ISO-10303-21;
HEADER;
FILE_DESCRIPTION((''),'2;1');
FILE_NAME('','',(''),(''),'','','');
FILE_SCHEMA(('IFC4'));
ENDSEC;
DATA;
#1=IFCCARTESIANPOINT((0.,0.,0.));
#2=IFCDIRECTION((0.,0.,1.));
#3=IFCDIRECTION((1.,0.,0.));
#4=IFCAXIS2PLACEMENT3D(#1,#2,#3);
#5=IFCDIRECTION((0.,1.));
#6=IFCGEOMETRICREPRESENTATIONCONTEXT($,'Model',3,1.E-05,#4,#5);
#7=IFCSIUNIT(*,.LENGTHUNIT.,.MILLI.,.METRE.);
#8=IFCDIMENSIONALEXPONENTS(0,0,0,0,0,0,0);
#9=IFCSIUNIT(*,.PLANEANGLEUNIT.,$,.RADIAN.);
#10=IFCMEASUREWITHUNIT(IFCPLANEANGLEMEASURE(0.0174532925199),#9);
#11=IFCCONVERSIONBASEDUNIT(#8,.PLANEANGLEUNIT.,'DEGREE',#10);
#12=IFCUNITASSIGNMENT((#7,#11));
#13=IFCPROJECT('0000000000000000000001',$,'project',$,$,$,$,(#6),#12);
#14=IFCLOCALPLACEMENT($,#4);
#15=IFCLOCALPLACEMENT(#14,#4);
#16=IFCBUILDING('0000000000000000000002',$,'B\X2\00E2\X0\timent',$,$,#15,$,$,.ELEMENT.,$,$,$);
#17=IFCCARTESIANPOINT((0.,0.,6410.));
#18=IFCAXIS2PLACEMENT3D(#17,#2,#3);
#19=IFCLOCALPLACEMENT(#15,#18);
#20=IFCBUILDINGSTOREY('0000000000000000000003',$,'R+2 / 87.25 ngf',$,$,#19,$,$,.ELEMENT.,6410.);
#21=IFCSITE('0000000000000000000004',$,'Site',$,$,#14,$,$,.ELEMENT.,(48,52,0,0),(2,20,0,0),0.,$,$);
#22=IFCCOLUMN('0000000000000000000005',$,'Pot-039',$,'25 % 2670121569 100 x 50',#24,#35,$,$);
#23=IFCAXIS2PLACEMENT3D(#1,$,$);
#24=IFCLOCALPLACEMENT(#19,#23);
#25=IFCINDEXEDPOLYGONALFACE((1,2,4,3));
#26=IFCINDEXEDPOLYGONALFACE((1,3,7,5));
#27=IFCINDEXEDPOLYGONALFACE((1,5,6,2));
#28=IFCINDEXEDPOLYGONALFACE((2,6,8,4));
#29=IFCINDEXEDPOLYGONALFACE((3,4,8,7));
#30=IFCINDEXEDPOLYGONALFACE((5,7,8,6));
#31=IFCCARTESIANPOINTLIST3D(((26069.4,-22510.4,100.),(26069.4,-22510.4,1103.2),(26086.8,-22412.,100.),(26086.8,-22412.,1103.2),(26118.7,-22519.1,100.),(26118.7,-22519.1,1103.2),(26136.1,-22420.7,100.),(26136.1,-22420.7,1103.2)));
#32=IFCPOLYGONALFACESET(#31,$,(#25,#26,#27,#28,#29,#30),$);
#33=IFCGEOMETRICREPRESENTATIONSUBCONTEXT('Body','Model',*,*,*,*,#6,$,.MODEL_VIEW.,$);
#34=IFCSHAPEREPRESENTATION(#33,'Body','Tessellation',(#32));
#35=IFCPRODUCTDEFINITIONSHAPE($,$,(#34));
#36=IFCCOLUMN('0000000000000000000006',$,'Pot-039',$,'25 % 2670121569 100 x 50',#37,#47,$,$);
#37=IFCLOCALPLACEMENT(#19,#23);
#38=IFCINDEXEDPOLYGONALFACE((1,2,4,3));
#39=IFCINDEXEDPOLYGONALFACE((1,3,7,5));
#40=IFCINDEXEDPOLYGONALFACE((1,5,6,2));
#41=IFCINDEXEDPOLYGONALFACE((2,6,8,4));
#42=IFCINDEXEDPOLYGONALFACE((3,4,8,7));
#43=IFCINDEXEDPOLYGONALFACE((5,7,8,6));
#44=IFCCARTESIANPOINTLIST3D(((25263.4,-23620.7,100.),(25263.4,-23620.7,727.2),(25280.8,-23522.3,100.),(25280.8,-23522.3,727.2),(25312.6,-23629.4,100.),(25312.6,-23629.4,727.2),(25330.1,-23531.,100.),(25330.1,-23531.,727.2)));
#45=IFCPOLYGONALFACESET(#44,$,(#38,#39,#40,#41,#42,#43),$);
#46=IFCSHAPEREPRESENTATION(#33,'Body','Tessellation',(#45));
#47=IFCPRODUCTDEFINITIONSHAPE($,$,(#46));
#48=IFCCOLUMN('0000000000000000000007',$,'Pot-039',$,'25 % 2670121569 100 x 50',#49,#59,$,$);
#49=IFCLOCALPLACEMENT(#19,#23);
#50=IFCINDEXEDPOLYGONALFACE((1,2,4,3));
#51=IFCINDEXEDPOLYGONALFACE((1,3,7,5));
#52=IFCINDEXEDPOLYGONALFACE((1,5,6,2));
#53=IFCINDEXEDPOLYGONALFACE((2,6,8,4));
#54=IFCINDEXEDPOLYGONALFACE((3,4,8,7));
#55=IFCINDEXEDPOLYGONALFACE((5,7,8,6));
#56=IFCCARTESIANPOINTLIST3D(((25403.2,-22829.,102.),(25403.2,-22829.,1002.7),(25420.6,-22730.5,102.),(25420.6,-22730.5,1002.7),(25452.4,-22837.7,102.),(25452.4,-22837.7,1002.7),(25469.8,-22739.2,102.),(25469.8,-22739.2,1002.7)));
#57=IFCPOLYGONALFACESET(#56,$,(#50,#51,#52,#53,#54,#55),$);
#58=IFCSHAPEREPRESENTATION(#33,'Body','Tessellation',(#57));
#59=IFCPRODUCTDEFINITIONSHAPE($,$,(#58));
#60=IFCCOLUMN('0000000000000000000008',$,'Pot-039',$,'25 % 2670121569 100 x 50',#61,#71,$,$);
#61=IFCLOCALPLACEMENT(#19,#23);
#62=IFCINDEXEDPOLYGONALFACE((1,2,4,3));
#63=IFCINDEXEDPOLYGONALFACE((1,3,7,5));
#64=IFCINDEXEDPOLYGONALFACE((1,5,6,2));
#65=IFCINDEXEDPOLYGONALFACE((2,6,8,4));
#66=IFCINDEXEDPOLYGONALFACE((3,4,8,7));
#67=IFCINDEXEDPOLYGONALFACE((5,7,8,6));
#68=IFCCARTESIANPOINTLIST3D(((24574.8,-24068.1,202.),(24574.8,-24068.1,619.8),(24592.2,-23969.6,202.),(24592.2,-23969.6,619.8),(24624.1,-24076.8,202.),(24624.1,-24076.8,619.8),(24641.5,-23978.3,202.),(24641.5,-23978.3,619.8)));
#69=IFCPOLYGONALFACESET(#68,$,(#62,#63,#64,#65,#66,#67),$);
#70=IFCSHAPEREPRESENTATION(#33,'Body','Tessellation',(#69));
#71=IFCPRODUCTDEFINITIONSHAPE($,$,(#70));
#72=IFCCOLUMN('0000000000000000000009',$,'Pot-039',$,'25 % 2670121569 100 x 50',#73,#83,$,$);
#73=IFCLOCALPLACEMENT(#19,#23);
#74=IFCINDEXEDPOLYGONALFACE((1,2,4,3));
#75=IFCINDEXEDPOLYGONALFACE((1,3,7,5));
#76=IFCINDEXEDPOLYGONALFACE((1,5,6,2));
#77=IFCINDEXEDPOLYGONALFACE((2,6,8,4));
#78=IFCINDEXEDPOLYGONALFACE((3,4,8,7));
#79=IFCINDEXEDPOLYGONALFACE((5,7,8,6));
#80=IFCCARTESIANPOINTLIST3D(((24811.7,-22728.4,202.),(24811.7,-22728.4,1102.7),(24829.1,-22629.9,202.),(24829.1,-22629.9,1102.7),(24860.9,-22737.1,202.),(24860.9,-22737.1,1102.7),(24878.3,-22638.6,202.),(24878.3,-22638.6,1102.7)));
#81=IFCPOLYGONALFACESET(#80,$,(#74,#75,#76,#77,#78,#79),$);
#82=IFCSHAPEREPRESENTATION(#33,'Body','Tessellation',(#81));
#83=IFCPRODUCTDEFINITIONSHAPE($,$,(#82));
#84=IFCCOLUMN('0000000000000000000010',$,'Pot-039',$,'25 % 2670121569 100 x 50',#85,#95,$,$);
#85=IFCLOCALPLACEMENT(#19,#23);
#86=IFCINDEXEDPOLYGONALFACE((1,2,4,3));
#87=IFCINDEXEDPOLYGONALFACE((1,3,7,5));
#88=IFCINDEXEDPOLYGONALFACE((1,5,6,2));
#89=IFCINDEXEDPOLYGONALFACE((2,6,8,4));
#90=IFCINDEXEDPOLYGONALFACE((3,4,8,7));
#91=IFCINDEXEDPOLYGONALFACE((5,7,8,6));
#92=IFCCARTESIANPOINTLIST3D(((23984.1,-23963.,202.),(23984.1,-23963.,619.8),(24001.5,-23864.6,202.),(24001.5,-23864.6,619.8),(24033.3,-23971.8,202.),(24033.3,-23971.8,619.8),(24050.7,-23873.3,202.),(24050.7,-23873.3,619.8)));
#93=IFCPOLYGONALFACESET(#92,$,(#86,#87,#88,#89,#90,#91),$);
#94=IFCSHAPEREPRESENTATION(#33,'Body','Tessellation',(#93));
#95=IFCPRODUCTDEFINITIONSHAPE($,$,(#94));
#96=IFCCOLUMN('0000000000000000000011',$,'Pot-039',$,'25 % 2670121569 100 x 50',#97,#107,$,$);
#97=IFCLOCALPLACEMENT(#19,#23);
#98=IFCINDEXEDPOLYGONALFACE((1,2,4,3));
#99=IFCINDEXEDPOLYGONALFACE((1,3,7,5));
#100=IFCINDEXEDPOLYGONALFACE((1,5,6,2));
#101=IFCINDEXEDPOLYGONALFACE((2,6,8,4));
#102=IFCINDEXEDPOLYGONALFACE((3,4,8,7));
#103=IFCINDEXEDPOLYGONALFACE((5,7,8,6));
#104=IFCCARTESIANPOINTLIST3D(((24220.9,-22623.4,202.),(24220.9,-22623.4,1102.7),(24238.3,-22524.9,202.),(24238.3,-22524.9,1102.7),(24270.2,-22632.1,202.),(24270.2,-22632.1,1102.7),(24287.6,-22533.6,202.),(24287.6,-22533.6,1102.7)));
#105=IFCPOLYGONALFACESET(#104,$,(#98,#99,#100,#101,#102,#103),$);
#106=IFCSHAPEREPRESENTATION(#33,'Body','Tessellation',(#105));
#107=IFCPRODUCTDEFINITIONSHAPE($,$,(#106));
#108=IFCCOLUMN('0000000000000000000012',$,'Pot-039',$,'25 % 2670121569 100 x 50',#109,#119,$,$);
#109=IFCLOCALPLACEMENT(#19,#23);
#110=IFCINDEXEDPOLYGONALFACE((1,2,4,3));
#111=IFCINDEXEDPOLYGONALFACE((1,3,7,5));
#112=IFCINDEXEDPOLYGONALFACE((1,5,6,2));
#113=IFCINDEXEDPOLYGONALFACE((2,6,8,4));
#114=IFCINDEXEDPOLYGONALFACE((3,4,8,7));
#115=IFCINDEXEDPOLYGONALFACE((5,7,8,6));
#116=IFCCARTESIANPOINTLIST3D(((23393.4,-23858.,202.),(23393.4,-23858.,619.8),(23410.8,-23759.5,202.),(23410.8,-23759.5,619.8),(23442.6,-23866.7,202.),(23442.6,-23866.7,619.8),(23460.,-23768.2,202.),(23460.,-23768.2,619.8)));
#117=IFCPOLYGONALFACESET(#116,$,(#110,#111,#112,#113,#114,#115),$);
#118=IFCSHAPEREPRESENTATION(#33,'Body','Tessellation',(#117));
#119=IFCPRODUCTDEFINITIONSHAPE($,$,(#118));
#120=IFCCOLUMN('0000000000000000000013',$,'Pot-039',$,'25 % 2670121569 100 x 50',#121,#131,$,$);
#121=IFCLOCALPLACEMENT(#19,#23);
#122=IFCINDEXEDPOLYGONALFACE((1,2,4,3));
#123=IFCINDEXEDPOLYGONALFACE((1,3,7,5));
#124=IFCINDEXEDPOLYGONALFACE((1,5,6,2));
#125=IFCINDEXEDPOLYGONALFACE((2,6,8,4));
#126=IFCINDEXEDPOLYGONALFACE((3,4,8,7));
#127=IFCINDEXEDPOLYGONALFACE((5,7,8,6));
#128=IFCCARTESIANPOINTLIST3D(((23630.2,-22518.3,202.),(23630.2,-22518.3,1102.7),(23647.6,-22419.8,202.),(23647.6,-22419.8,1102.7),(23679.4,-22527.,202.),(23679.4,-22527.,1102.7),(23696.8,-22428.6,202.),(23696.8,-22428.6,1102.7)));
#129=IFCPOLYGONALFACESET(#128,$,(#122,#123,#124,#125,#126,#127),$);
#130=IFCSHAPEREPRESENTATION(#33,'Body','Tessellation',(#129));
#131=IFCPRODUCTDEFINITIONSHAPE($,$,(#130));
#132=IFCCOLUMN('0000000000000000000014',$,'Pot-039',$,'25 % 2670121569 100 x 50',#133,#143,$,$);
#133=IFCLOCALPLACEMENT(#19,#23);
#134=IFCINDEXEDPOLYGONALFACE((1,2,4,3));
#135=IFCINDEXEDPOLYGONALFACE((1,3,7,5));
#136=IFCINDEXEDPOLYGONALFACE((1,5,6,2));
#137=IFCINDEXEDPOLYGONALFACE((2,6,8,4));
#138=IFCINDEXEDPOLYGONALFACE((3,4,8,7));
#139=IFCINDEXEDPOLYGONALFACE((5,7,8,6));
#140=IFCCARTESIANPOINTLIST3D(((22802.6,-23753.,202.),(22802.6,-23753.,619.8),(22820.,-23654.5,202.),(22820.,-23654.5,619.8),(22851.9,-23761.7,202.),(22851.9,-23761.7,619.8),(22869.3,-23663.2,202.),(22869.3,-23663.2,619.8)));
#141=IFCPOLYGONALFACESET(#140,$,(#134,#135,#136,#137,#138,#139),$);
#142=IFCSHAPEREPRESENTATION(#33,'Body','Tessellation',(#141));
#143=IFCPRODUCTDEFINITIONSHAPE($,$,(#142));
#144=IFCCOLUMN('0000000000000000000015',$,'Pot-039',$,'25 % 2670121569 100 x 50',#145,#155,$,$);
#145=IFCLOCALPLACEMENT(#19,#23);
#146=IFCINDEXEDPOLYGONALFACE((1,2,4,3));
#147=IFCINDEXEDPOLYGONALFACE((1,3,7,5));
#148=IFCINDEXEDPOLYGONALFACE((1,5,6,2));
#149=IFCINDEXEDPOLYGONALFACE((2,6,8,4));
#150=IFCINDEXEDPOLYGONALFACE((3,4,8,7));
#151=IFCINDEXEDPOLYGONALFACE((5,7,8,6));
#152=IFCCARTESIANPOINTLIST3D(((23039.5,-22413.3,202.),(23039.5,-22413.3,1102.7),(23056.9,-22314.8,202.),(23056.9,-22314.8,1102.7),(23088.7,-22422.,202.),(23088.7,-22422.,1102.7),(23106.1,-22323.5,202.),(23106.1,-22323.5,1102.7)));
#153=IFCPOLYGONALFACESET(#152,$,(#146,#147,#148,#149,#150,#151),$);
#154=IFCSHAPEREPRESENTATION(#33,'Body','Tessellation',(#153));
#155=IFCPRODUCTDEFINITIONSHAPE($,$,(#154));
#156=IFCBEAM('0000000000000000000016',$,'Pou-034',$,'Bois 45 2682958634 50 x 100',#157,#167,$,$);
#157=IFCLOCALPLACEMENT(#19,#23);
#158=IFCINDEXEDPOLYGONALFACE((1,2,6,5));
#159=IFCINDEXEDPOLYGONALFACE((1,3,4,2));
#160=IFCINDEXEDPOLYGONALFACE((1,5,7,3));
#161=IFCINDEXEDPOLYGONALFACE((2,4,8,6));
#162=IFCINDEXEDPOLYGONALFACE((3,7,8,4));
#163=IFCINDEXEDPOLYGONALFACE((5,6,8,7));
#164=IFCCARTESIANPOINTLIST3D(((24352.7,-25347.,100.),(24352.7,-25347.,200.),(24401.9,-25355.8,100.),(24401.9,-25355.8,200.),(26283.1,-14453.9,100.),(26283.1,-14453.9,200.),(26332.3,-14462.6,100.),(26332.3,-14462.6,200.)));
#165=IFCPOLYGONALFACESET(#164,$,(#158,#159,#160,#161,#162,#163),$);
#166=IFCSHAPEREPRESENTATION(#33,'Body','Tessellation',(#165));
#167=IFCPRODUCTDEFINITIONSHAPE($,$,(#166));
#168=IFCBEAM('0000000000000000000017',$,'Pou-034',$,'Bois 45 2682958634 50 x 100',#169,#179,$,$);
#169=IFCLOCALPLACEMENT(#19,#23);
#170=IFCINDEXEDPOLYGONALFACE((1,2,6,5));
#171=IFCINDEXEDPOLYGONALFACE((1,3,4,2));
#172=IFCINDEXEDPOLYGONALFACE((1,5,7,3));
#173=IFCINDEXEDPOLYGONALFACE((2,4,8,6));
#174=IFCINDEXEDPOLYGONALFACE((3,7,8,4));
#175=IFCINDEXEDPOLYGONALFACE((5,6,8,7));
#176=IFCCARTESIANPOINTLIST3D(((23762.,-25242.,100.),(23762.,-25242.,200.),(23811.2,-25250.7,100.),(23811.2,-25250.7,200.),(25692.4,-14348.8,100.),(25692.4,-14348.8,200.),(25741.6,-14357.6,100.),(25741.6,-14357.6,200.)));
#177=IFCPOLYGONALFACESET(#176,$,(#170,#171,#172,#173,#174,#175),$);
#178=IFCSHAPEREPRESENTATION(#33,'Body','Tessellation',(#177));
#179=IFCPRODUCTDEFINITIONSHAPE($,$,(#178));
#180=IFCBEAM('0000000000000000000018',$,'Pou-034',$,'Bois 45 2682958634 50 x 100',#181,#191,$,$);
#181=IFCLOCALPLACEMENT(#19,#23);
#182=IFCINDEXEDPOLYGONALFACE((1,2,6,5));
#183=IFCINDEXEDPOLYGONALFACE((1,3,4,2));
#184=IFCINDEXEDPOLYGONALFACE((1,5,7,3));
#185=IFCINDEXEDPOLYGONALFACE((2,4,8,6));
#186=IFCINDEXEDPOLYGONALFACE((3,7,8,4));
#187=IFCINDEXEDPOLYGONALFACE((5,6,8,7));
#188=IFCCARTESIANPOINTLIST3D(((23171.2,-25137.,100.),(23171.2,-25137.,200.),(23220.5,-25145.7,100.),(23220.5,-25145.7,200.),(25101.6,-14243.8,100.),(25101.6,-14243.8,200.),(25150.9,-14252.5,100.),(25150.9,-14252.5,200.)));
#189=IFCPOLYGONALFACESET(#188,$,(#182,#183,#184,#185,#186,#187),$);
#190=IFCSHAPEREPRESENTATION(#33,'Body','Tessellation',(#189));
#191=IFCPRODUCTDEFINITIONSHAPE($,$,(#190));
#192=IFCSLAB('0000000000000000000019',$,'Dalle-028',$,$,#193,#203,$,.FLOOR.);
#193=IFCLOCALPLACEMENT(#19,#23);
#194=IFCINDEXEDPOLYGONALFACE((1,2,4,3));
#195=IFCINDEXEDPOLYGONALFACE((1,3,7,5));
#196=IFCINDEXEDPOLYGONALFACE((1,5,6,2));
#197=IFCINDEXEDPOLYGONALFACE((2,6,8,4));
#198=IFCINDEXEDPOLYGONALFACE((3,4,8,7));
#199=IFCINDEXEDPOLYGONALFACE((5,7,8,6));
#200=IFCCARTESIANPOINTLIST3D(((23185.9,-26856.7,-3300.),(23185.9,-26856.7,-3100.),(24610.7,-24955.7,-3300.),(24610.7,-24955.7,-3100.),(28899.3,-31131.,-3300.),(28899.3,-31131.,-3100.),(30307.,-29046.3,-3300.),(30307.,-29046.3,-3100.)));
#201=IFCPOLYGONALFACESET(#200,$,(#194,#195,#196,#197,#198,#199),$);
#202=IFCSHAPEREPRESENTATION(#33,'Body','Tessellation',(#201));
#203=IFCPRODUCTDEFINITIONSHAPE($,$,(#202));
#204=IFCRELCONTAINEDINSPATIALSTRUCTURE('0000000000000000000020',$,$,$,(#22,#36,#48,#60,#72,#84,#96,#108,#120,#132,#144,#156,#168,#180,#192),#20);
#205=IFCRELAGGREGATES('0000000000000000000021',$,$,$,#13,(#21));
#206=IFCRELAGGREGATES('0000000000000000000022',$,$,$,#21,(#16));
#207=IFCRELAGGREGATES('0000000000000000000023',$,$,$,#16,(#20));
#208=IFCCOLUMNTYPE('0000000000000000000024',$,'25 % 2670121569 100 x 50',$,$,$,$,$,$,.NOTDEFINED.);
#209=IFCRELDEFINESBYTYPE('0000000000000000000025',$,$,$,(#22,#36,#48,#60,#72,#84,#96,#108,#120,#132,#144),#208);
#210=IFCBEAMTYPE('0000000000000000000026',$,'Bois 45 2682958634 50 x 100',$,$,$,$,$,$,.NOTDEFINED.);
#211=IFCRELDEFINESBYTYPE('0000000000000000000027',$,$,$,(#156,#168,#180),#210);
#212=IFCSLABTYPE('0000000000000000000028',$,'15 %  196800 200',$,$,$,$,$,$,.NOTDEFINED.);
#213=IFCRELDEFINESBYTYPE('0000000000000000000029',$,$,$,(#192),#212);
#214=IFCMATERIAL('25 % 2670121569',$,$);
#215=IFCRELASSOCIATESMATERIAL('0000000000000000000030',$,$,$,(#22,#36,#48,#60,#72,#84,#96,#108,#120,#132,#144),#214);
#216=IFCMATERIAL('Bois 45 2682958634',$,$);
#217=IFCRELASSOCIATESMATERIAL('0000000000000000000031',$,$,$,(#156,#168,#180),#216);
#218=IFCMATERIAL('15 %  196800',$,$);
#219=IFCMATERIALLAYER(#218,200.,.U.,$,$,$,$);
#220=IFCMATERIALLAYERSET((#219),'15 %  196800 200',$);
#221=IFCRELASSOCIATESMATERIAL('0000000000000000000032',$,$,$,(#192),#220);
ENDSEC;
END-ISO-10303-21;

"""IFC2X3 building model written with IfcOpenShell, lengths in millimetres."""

from ifc_helpers import new_model, entity, si_unit, converted_unit, direction, frame, frame_2d, origin_with_axes, origin_2d_with_axis, place, context, subcontext, project, spatial, polyline, rectangle, outline, extrude, material, layer, layer_set, layer_usage, type_object, element, save


model = new_model("IFC2X3")

# Units and contexts
model_context = context("Model", 3, precision=1e-05, world=origin_with_axes(), true_north=direction((0.0, 1.0)))
body_context = subcontext(model_context, "Body", "Model", "MODEL_VIEW")
ifc_project = project(units=[si_unit("LENGTHUNIT", "METRE", prefix="MILLI"), converted_unit("PLANEANGLEUNIT", "DEGREE", entity("IfcPlaneAngleMeasure", 0.0174532925199), si_unit("PLANEANGLEUNIT", "RADIAN"), dimensions=[0, 0, 0, 0, 0, 0, 0])], contexts=[model_context])

# Site, building, storey
site_placement = place(None, origin_with_axes())
site = spatial("IfcSite", under=ifc_project, at=site_placement, Name="Site", CompositionType="ELEMENT", RefLatitude=(48, 52, 0, 0), RefLongitude=(2, 20, 0, 0), RefElevation=0.0)
building_placement = place(site_placement, origin_with_axes())
building = spatial("IfcBuilding", under=site, at=building_placement, Name="Bâtiment", CompositionType="ELEMENT")
storey_placement = place(building_placement, frame((0.0, 0.0, 6410.0), z_axis=(0.0, 0.0, 1.0), x_axis=(1.0, 0.0, 0.0)))
storey = spatial("IfcBuildingStorey", under=building, at=storey_placement, Name="R+2 / 87.25 ngf", CompositionType="ELEMENT", Elevation=6410.0)

# Columns
ifc_material_1 = material(Name="25 % 2670121569")
column_type = type_object("IfcColumnType", Name="25 % 2670121569 100 x 50", PredefinedType="NOTDEFINED")
column_1_placement = place(storey_placement, frame((26102.8, -22465.5, 100.0), z_axis=(0.0, 0.0, 1.0), x_axis=(0.17408, 0.984731, 0.0)))
element("IfcColumn", 1, at=column_1_placement, inside=storey, type_object=column_type, material=ifc_material_1, Name="Pot-039", ObjectType="25 % 2670121569 100 x 50", context=body_context, shape_type="SweptSolid", body=[
    extrude(rectangle(XDim=100.0, YDim=50.0, at=origin_2d_with_axis()), origin_with_axes(), (0.0, 0.0, 1.0), 1003.2),
])
column_2_placement = place(storey_placement, frame((25296.7, -23575.9, 100.0), z_axis=(0.0, 0.0, 1.0), x_axis=(0.17408, 0.984731, 0.0)))
element("IfcColumn", 2, at=column_2_placement, inside=storey, type_object=column_type, material=ifc_material_1, Name="Pot-039", ObjectType="25 % 2670121569 100 x 50", context=body_context, shape_type="SweptSolid", body=[
    extrude(rectangle(XDim=100.0, YDim=50.0, at=origin_2d_with_axis()), origin_with_axes(), (0.0, 0.0, 1.0), 627.2),
])
column_3_placement = place(storey_placement, frame((25436.5, -22784.1, 102.0), z_axis=(0.0, 0.0, 1.0), x_axis=(0.17408, 0.984731, 0.0)))
element("IfcColumn", 3, at=column_3_placement, inside=storey, type_object=column_type, material=ifc_material_1, Name="Pot-039", ObjectType="25 % 2670121569 100 x 50", context=body_context, shape_type="SweptSolid", body=[
    extrude(rectangle(XDim=100.0, YDim=50.0, at=origin_2d_with_axis()), origin_with_axes(), (0.0, 0.0, 1.0), 900.7),
])
column_4_placement = place(storey_placement, frame((24608.1, -24023.2, 202.0), z_axis=(0.0, 0.0, 1.0), x_axis=(0.17408, 0.984731, 0.0)))
element("IfcColumn", 4, at=column_4_placement, inside=storey, type_object=column_type, material=ifc_material_1, Name="Pot-039", ObjectType="25 % 2670121569 100 x 50", context=body_context, shape_type="SweptSolid", body=[
    extrude(rectangle(XDim=100.0, YDim=50.0, at=origin_2d_with_axis()), origin_with_axes(), (0.0, 0.0, 1.0), 417.8),
])
column_5_placement = place(storey_placement, frame((24845.0, -22683.5, 202.0), z_axis=(0.0, 0.0, 1.0), x_axis=(0.17408, 0.984731, 0.0)))
element("IfcColumn", 5, at=column_5_placement, inside=storey, type_object=column_type, material=ifc_material_1, Name="Pot-039", ObjectType="25 % 2670121569 100 x 50", context=body_context, shape_type="SweptSolid", body=[
    extrude(rectangle(XDim=100.0, YDim=50.0, at=origin_2d_with_axis()), origin_with_axes(), (0.0, 0.0, 1.0), 900.7),
])
column_6_placement = place(storey_placement, frame((24017.4, -23918.2, 202.0), z_axis=(0.0, 0.0, 1.0), x_axis=(0.17408, 0.984731, 0.0)))
element("IfcColumn", 6, at=column_6_placement, inside=storey, type_object=column_type, material=ifc_material_1, Name="Pot-039", ObjectType="25 % 2670121569 100 x 50", context=body_context, shape_type="SweptSolid", body=[
    extrude(rectangle(XDim=100.0, YDim=50.0, at=origin_2d_with_axis()), origin_with_axes(), (0.0, 0.0, 1.0), 417.8),
])
column_7_placement = place(storey_placement, frame((24254.3, -22578.5, 202.0), z_axis=(0.0, 0.0, 1.0), x_axis=(0.17408, 0.984731, 0.0)))
element("IfcColumn", 7, at=column_7_placement, inside=storey, type_object=column_type, material=ifc_material_1, Name="Pot-039", ObjectType="25 % 2670121569 100 x 50", context=body_context, shape_type="SweptSolid", body=[
    extrude(rectangle(XDim=100.0, YDim=50.0, at=origin_2d_with_axis()), origin_with_axes(), (0.0, 0.0, 1.0), 900.7),
])
column_8_placement = place(storey_placement, frame((23426.7, -23813.1, 202.0), z_axis=(0.0, 0.0, 1.0), x_axis=(0.17408, 0.984731, 0.0)))
element("IfcColumn", 8, at=column_8_placement, inside=storey, type_object=column_type, material=ifc_material_1, Name="Pot-039", ObjectType="25 % 2670121569 100 x 50", context=body_context, shape_type="SweptSolid", body=[
    extrude(rectangle(XDim=100.0, YDim=50.0, at=origin_2d_with_axis()), origin_with_axes(), (0.0, 0.0, 1.0), 417.8),
])
column_9_placement = place(storey_placement, frame((23663.5, -22473.4, 202.0), z_axis=(0.0, 0.0, 1.0), x_axis=(0.17408, 0.984731, 0.0)))
element("IfcColumn", 9, at=column_9_placement, inside=storey, type_object=column_type, material=ifc_material_1, Name="Pot-039", ObjectType="25 % 2670121569 100 x 50", context=body_context, shape_type="SweptSolid", body=[
    extrude(rectangle(XDim=100.0, YDim=50.0, at=origin_2d_with_axis()), origin_with_axes(), (0.0, 0.0, 1.0), 900.7),
])
column_10_placement = place(storey_placement, frame((22835.9, -23708.1, 202.0), z_axis=(0.0, 0.0, 1.0), x_axis=(0.17408, 0.984731, 0.0)))
element("IfcColumn", 10, at=column_10_placement, inside=storey, type_object=column_type, material=ifc_material_1, Name="Pot-039", ObjectType="25 % 2670121569 100 x 50", context=body_context, shape_type="SweptSolid", body=[
    extrude(rectangle(XDim=100.0, YDim=50.0, at=origin_2d_with_axis()), origin_with_axes(), (0.0, 0.0, 1.0), 417.8),
])
column_11_placement = place(storey_placement, frame((23072.8, -22368.4, 202.0), z_axis=(0.0, 0.0, 1.0), x_axis=(0.17408, 0.984731, 0.0)))
element("IfcColumn", 11, at=column_11_placement, inside=storey, type_object=column_type, material=ifc_material_1, Name="Pot-039", ObjectType="25 % 2670121569 100 x 50", context=body_context, shape_type="SweptSolid", body=[
    extrude(rectangle(XDim=100.0, YDim=50.0, at=origin_2d_with_axis()), origin_with_axes(), (0.0, 0.0, 1.0), 900.7),
])

# Beams
ifc_material_2 = material(Name="Bois 45 2682958634")
beam_type_1 = type_object("IfcBeamType", Name="Bois 45 2682958634 50 x 100", PredefinedType="NOTDEFINED")
for number, where, z_axis, x_axis, name in (
    (12, (24377.3, -25351.4, 200.0), (0.0, 0.0, 1.0), (0.984659, -0.174492, 0.0), "Pou-034"),
    (13, (23786.6, -25246.4, 200.0), (0.0, 0.0, 1.0), (0.984659, -0.174492, 0.0), "Pou-034"),
    (14, (23195.8, -25141.3, 200.0), (0.0, 0.0, 1.0), (0.984659, -0.174492, 0.0), "Pou-034"),
):
    element("IfcBeam", number, at=place(storey_placement, frame(where, z_axis=z_axis, x_axis=x_axis)), inside=storey, type_object=beam_type_1, material=ifc_material_2, Name=name, ObjectType="Bois 45 2682958634 50 x 100", context=body_context, shape_type="SweptSolid", body=[
        extrude(rectangle(XDim=100.0, YDim=50.0, at=frame_2d((-50.0, 0.0), x_axis=(1.0, 0.0))), frame((0.0, 0.0, 0.0), z_axis=(0.0, 1.0, 0.0), x_axis=(0.0, 0.0, 1.0)), (0.0, 0.0, 1.0), 11062.9),
    ])

# Slab
ifc_material_3 = material(Name="15 %  196800")
ifc_layer_1 = layer(ifc_material_3, 200.0, ventilated="UNKNOWN")
ifc_layer_set_1 = layer_set([ifc_layer_1], Name="15 %  196800 200")
ifc_layer_usage_1 = layer_usage(ifc_layer_set_1, "AXIS3", "NEGATIVE", 200.0)
slab_type = type_object("IfcSlabType", Name="15 %  196800 200", PredefinedType="NOTDEFINED")
slab_1_placement = place(storey_placement, frame((23185.9, -26856.7, -3100.0), z_axis=(0.0, 0.0, 1.0), x_axis=(1.0, 0.0, 0.0)))
element("IfcSlab", 15, at=slab_1_placement, inside=storey, type_object=slab_type, material=ifc_layer_usage_1, Name="Dalle-028", PredefinedType="FLOOR", context=body_context, shape_type="SweptSolid", body=[
    extrude(outline(polyline([(0.0, 0.0), (5713.4, -4274.3), (7121.1, -2189.5), (1424.8, 1901.0), (0.0, 0.0)])), frame((0.0, 0.0, -200.0), z_axis=(0.0, 0.0, 1.0), x_axis=(1.0, 0.0, 0.0)), (0.0, 0.0, 1.0), 200.0),
])

save(model, "model.ifc")
